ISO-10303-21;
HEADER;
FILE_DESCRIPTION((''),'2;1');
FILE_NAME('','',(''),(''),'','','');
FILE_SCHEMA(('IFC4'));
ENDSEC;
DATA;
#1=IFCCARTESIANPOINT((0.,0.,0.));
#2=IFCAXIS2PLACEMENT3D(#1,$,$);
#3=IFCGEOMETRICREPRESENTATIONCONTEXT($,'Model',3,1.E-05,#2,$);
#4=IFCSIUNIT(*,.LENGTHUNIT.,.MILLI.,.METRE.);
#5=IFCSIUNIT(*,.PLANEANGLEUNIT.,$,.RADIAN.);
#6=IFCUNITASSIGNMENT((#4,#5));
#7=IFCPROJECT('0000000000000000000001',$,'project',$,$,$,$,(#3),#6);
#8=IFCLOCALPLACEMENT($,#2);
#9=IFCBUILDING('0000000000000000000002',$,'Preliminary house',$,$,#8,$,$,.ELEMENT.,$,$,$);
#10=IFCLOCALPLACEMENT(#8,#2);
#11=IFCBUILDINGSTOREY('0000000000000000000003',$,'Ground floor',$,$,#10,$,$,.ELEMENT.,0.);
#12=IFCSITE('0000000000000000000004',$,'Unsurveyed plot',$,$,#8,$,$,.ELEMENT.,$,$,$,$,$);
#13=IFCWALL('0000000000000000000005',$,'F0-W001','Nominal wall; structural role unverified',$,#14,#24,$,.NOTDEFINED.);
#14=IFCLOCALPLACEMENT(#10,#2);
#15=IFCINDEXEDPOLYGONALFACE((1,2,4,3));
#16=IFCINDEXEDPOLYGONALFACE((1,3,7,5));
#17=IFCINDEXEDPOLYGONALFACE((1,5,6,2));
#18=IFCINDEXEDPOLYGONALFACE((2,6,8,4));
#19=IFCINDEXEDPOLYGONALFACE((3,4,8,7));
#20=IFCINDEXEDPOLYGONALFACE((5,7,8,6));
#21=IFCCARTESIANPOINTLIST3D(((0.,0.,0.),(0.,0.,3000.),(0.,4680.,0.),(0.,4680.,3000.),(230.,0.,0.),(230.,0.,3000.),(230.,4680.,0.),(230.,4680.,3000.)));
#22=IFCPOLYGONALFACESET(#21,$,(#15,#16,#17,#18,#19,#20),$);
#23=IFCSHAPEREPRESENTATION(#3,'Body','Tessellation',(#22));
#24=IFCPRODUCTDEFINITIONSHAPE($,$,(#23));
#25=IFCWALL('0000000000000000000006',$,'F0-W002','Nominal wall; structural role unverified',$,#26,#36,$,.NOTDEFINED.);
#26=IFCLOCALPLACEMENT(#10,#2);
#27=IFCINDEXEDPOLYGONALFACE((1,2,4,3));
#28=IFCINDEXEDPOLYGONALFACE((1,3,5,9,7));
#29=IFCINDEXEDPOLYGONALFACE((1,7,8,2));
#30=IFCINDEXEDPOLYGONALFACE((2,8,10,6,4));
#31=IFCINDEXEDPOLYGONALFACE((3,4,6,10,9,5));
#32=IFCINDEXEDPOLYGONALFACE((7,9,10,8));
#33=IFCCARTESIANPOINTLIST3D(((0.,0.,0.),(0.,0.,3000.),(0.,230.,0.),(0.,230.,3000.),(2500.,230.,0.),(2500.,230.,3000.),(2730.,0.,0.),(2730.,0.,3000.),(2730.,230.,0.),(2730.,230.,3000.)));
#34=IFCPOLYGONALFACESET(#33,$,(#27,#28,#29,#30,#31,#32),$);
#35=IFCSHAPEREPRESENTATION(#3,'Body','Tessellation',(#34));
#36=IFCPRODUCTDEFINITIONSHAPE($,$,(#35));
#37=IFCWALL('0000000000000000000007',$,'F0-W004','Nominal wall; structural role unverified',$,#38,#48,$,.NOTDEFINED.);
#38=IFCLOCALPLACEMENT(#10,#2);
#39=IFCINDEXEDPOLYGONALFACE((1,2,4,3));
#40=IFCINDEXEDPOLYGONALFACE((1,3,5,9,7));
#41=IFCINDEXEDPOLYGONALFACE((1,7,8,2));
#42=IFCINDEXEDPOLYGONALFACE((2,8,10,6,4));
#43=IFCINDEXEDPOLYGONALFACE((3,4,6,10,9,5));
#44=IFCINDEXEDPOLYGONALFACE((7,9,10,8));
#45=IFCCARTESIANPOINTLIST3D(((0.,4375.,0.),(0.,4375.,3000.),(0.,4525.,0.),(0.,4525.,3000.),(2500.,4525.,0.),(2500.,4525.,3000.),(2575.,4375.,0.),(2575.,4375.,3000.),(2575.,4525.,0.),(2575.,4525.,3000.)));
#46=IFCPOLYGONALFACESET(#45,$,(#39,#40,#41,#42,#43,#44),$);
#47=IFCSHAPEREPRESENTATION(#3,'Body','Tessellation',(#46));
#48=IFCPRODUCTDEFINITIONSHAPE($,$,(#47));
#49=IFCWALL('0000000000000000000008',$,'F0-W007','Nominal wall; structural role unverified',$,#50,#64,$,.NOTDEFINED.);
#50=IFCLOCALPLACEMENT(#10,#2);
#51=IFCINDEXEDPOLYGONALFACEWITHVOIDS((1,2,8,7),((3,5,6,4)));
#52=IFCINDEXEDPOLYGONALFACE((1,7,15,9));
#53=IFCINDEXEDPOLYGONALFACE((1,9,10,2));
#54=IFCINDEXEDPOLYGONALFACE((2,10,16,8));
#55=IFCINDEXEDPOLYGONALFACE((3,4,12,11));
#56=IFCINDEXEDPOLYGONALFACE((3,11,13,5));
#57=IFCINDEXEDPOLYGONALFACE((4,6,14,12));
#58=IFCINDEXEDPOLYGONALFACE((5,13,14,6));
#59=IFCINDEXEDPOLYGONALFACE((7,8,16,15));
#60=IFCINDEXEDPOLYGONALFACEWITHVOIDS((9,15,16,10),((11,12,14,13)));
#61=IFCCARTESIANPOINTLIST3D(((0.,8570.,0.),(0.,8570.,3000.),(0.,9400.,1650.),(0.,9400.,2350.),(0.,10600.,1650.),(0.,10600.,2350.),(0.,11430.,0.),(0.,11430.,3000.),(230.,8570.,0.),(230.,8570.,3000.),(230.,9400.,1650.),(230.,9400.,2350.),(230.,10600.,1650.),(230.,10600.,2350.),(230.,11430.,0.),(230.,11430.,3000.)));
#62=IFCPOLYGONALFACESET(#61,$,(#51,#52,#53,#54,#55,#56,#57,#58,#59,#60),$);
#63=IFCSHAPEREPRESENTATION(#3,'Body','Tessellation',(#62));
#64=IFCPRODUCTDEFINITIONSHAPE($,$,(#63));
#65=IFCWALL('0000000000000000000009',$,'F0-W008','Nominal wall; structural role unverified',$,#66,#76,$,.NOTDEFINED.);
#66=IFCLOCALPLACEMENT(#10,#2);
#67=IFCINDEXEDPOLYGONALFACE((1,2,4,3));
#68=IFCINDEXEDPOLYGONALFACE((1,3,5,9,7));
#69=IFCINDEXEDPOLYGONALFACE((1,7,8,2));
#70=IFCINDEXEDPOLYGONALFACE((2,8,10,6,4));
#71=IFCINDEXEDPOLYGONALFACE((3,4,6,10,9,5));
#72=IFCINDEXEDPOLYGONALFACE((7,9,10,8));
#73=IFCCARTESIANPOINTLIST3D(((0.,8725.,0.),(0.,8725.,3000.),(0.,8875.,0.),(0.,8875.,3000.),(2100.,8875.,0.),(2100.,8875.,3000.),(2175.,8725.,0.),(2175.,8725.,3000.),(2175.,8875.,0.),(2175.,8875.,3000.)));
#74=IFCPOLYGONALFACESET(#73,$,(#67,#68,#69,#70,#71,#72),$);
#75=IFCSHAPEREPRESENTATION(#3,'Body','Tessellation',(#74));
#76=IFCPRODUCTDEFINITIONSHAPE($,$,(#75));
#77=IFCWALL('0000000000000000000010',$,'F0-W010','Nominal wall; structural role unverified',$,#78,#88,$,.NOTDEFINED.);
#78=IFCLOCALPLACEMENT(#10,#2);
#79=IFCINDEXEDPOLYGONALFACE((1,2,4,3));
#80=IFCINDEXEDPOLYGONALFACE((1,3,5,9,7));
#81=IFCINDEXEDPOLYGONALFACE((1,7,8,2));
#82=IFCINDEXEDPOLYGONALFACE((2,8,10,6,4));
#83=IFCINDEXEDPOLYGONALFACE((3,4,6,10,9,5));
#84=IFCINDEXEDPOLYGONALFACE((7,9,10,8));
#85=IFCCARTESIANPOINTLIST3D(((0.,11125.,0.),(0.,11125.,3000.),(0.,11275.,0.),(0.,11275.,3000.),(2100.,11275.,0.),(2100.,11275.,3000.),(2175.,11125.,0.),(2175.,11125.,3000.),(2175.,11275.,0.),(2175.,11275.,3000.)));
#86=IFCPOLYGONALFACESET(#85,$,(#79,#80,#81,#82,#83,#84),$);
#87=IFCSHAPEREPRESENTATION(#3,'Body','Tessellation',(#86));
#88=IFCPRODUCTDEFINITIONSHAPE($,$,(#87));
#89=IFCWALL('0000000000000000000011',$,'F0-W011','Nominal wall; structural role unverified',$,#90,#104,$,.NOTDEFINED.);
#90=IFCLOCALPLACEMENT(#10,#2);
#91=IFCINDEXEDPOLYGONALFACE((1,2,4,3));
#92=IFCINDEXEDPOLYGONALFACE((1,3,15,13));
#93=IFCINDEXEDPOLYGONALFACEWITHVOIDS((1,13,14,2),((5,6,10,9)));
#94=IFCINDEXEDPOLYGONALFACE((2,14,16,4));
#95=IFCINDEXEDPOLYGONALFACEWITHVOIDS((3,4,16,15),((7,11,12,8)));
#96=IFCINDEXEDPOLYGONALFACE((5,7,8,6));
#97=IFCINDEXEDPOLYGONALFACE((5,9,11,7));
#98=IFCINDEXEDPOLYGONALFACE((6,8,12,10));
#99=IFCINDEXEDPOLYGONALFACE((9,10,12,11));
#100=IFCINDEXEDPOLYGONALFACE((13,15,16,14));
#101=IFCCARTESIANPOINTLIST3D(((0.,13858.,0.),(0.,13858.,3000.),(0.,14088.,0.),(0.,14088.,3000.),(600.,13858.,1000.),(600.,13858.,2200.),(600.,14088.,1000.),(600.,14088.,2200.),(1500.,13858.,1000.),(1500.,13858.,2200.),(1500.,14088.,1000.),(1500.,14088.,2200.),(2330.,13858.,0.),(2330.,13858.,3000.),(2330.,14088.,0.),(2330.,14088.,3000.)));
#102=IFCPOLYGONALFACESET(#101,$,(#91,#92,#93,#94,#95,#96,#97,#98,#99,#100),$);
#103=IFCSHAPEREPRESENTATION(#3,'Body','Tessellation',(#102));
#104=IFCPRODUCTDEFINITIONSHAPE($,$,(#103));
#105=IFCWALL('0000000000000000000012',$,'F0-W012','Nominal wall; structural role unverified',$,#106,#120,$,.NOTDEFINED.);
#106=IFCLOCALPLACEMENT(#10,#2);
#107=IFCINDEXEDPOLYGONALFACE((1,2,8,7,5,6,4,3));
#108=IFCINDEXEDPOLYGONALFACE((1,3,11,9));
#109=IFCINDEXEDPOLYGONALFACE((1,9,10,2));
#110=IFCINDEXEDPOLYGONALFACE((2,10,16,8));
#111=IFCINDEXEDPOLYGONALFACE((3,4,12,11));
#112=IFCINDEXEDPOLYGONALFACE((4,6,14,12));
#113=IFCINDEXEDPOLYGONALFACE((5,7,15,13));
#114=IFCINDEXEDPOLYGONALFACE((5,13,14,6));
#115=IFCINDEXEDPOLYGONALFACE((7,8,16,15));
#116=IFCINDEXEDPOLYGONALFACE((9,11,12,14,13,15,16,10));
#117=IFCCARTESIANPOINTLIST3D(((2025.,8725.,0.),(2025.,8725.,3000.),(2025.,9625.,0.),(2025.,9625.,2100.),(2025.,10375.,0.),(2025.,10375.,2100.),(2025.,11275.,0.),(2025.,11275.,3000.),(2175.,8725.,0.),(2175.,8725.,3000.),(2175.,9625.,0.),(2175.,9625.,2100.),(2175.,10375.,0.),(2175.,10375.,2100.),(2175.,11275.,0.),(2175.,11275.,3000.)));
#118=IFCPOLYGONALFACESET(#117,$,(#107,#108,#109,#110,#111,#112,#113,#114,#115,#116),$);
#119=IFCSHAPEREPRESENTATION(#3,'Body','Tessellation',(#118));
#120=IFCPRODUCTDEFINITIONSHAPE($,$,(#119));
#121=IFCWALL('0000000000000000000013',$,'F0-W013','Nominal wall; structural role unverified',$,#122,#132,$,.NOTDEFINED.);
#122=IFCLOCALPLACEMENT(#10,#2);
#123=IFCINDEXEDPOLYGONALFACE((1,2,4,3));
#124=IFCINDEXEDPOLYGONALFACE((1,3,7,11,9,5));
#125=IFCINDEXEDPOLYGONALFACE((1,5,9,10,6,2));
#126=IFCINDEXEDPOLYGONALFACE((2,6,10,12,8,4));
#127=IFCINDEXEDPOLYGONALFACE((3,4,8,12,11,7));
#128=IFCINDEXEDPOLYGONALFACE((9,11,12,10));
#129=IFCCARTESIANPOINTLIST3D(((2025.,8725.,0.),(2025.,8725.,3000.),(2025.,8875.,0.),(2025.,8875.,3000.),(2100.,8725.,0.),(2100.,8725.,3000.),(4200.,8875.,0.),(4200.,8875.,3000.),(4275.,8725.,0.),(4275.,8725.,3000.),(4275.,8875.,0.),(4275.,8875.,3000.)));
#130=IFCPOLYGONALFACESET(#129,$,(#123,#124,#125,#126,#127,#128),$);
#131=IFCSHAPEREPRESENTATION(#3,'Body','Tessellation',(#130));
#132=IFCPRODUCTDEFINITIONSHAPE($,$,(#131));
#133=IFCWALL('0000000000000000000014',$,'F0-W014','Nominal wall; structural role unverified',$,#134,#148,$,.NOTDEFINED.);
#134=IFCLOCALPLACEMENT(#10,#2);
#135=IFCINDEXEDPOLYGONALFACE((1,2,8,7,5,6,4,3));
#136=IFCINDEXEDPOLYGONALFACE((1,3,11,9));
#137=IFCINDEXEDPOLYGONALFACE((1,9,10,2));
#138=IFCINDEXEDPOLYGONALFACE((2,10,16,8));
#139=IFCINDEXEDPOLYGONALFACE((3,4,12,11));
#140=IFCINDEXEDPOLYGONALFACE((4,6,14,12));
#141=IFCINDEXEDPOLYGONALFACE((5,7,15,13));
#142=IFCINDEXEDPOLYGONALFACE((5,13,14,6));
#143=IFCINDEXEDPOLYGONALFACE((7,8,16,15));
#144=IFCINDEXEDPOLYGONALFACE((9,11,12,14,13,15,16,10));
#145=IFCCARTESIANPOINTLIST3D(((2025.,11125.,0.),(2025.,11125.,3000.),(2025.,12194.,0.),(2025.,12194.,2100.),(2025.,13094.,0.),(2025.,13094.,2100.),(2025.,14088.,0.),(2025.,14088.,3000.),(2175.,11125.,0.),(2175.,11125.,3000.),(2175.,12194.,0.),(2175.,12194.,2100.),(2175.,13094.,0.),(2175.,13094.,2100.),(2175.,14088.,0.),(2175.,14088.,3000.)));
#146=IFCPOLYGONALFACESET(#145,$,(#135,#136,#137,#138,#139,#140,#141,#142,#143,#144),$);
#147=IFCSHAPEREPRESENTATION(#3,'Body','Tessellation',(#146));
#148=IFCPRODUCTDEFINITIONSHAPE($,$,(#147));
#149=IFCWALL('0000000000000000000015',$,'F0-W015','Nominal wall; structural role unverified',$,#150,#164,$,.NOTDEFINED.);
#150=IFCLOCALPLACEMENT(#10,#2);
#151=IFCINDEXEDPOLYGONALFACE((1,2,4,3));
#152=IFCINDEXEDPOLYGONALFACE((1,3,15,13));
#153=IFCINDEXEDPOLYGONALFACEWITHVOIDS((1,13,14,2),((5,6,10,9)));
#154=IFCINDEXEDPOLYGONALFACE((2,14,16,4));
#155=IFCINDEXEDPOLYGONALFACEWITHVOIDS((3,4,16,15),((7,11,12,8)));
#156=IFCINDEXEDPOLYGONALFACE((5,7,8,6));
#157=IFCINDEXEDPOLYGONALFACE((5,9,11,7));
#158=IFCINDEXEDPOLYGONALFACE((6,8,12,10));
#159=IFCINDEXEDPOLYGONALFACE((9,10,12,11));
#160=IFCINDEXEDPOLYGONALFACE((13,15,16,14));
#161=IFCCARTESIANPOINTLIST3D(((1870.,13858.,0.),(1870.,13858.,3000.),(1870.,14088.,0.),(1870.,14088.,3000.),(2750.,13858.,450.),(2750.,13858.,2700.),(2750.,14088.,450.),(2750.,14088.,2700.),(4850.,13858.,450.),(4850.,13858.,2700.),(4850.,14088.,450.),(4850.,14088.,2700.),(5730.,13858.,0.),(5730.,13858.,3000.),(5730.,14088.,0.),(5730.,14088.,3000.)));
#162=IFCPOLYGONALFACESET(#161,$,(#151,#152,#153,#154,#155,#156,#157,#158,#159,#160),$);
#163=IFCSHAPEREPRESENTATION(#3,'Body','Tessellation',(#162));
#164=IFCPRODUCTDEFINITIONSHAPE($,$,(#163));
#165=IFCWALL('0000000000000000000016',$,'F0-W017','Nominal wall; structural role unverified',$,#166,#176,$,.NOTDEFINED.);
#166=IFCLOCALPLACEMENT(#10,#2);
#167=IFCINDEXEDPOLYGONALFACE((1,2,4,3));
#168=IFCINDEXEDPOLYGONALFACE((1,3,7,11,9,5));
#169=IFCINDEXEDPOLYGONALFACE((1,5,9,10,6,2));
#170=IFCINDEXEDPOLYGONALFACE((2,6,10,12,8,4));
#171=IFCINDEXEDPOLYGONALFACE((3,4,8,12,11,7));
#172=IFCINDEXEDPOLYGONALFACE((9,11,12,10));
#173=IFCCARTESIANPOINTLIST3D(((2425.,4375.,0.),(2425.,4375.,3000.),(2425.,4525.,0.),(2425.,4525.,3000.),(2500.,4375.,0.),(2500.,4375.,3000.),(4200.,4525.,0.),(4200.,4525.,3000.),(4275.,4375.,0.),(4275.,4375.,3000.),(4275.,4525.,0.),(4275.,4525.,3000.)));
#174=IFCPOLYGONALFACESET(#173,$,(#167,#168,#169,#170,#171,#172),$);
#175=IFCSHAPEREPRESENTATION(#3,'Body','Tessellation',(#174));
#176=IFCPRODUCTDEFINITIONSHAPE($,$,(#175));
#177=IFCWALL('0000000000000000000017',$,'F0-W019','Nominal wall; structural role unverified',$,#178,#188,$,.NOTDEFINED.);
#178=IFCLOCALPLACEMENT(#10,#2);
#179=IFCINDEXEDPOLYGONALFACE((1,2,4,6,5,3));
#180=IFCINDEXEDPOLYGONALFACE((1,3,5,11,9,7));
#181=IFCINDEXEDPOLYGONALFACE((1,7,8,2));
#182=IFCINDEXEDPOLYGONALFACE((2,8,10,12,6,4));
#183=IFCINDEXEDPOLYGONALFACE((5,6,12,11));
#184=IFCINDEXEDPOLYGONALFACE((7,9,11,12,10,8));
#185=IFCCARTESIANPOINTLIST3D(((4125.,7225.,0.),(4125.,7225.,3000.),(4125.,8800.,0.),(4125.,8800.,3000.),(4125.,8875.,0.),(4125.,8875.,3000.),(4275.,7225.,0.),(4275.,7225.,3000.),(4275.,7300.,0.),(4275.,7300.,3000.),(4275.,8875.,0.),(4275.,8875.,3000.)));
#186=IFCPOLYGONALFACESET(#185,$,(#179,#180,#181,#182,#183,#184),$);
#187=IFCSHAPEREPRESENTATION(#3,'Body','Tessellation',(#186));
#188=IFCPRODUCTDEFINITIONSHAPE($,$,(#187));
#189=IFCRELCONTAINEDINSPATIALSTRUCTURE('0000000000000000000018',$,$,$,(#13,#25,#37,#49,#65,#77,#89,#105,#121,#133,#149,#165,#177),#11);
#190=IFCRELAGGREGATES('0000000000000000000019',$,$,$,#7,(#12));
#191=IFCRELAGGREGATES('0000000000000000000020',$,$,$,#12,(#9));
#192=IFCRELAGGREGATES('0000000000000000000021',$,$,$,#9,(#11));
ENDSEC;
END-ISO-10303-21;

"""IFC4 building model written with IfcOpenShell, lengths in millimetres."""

from ifc_helpers import new_model, si_unit, frame, origin, place, context, project, spatial, polyline, outline, extrude, element, save


model = new_model("IFC4")

# Units and contexts
model_context = context("Model", 3, precision=1e-05, world=origin())
ifc_project = project(units=[si_unit("LENGTHUNIT", "METRE", prefix="MILLI"), si_unit("PLANEANGLEUNIT", "RADIAN")], contexts=[model_context])

# Site, building, storey
placement_1 = place(None, origin())
site = spatial("IfcSite", under=ifc_project, at=placement_1, Name="Unsurveyed plot", CompositionType="ELEMENT")
building = spatial("IfcBuilding", under=site, at=placement_1, Name="Preliminary house", CompositionType="ELEMENT")
placement_2 = place(placement_1, origin())
storey = spatial("IfcBuildingStorey", under=building, at=placement_2, Name="Ground floor", CompositionType="ELEMENT", Elevation=0.0)

# Walls
element("IfcWall", 1, at=placement_2, inside=storey, Name="F0-W001", Description="Nominal wall; structural role unverified", PredefinedType="NOTDEFINED", context=model_context, shape_type="SweptSolid", body=[
    extrude(outline(polyline([(230.0, 4680.0), (230.0, 0.0), (0.0, 0.0), (0.0, 4680.0), (230.0, 4680.0)])), origin(), (0.0, 0.0, 1.0), 3000.0),
])
element("IfcWall", 2, at=placement_2, inside=storey, Name="F0-W002", Description="Nominal wall; structural role unverified", PredefinedType="NOTDEFINED", context=model_context, shape_type="SweptSolid", body=[
    extrude(outline(polyline([(2730.0, 230.0), (2730.0, 0.0), (0.0, 0.0), (0.0, 230.0), (2500.0, 230.0), (2730.0, 230.0)])), origin(), (0.0, 0.0, 1.0), 3000.0),
])

# Wall
element("IfcWall", 3, at=placement_2, inside=storey, Name="F0-W004", Description="Nominal wall; structural role unverified", PredefinedType="NOTDEFINED", context=model_context, shape_type="SweptSolid", body=[
    extrude(outline(polyline([(2575.0, 4525.0), (2575.0, 4375.0), (0.0, 4375.0), (0.0, 4525.0), (2500.0, 4525.0), (2575.0, 4525.0)])), origin(), (0.0, 0.0, 1.0), 3000.0),
])

# Wall, opening
wall_1 = element("IfcWall", 4, at=placement_2, inside=storey, Name="F0-W007", Description="Nominal wall; structural role unverified", PredefinedType="NOTDEFINED", context=model_context, shape_type="SweptSolid", body=[
    extrude(outline(polyline([(230.0, 11430.0), (230.0, 8800.0), (230.0, 8570.0), (0.0, 8570.0), (0.0, 11430.0), (230.0, 11430.0)])), origin(), (0.0, 0.0, 1.0), 3000.0),
])
element("IfcOpeningElement", 5, at=placement_2, cuts=wall_1, PredefinedType="OPENING", context=model_context, shape_type="SweptSolid", body=[
    extrude(outline(polyline([(645.0, 9400.0), (645.0, 10600.0), (-415.0, 10600.0), (-415.0, 9400.0), (645.0, 9400.0)])), frame((0.0, 0.0, 1650.0)), (0.0, 0.0, 1.0), 700.0),
])

# Wall
element("IfcWall", 6, at=placement_2, inside=storey, Name="F0-W008", Description="Nominal wall; structural role unverified", PredefinedType="NOTDEFINED", context=model_context, shape_type="SweptSolid", body=[
    extrude(outline(polyline([(2175.0, 8875.0), (2175.0, 8725.0), (0.0, 8725.0), (0.0, 8875.0), (2100.0, 8875.0), (2175.0, 8875.0)])), origin(), (0.0, 0.0, 1.0), 3000.0),
])

# Wall
element("IfcWall", 7, at=placement_2, inside=storey, Name="F0-W010", Description="Nominal wall; structural role unverified", PredefinedType="NOTDEFINED", context=model_context, shape_type="SweptSolid", body=[
    extrude(outline(polyline([(2175.0, 11275.0), (2175.0, 11125.0), (0.0, 11125.0), (0.0, 11275.0), (2100.0, 11275.0), (2175.0, 11275.0)])), origin(), (0.0, 0.0, 1.0), 3000.0),
])

# Walls, openings
wall_2 = element("IfcWall", 8, at=placement_2, inside=storey, Name="F0-W011", Description="Nominal wall; structural role unverified", PredefinedType="NOTDEFINED", context=model_context, shape_type="SweptSolid", body=[
    extrude(outline(polyline([(2330.0, 13858.0), (0.0, 13858.0), (0.0, 14088.0), (2330.0, 14088.0), (2330.0, 13858.0)])), origin(), (0.0, 0.0, 1.0), 3000.0),
])
element("IfcOpeningElement", 9, at=placement_2, cuts=wall_2, PredefinedType="OPENING", context=model_context, shape_type="SweptSolid", body=[
    extrude(outline(polyline([(600.0, 13443.0), (1500.0, 13443.0), (1500.0, 14503.0), (600.0, 14503.0), (600.0, 13443.0)])), frame((0.0, 0.0, 1000.0)), (0.0, 0.0, 1.0), 1200.0),
])
wall_3 = element("IfcWall", 10, at=placement_2, inside=storey, Name="F0-W012", Description="Nominal wall; structural role unverified", PredefinedType="NOTDEFINED", context=model_context, shape_type="SweptSolid", body=[
    extrude(outline(polyline([(2025.0, 11275.0), (2175.0, 11275.0), (2175.0, 8800.0), (2175.0, 8725.0), (2025.0, 8725.0), (2025.0, 11200.0), (2025.0, 11275.0)])), origin(), (0.0, 0.0, 1.0), 3000.0),
])
element("IfcOpeningElement", 11, at=placement_2, cuts=wall_3, PredefinedType="OPENING", context=model_context, shape_type="SweptSolid", body=[
    extrude(outline(polyline([(2550.0, 9625.0), (2550.0, 10375.0), (1650.0, 10375.0), (1650.0, 9625.0), (2550.0, 9625.0)])), origin(), (0.0, 0.0, 1.0), 2100.0),
])

# Wall
element("IfcWall", 12, at=placement_2, inside=storey, Name="F0-W013", Description="Nominal wall; structural role unverified", PredefinedType="NOTDEFINED", context=model_context, shape_type="SweptSolid", body=[
    extrude(outline(polyline([(4275.0, 8875.0), (4275.0, 8725.0), (2100.0, 8725.0), (2025.0, 8725.0), (2025.0, 8875.0), (4200.0, 8875.0), (4275.0, 8875.0)])), origin(), (0.0, 0.0, 1.0), 3000.0),
])

# Walls, openings
wall_4 = element("IfcWall", 13, at=placement_2, inside=storey, Name="F0-W014", Description="Nominal wall; structural role unverified", PredefinedType="NOTDEFINED", context=model_context, shape_type="SweptSolid", body=[
    extrude(outline(polyline([(2175.0, 11200.0), (2175.0, 11125.0), (2025.0, 11125.0), (2025.0, 14088.0), (2175.0, 14088.0), (2175.0, 11200.0)])), origin(), (0.0, 0.0, 1.0), 3000.0),
])
element("IfcOpeningElement", 14, at=placement_2, cuts=wall_4, PredefinedType="OPENING", context=model_context, shape_type="SweptSolid", body=[
    extrude(outline(polyline([(2550.0, 12194.0), (2550.0, 13094.0), (1650.0, 13094.0), (1650.0, 12194.0), (2550.0, 12194.0)])), origin(), (0.0, 0.0, 1.0), 2100.0),
])
wall_5 = element("IfcWall", 15, at=placement_2, inside=storey, Name="F0-W015", Description="Nominal wall; structural role unverified", PredefinedType="NOTDEFINED", context=model_context, shape_type="SweptSolid", body=[
    extrude(outline(polyline([(5730.0, 13858.0), (2100.0, 13858.0), (1870.0, 13858.0), (1870.0, 14088.0), (5730.0, 14088.0), (5730.0, 13858.0)])), origin(), (0.0, 0.0, 1.0), 3000.0),
])
element("IfcOpeningElement", 16, at=placement_2, cuts=wall_5, PredefinedType="OPENING", context=model_context, shape_type="SweptSolid", body=[
    extrude(outline(polyline([(2750.0, 13443.0), (4850.0, 13443.0), (4850.0, 14503.0), (2750.0, 14503.0), (2750.0, 13443.0)])), frame((0.0, 0.0, 450.0)), (0.0, 0.0, 1.0), 2250.0),
])

# Wall
element("IfcWall", 17, at=placement_2, inside=storey, Name="F0-W017", Description="Nominal wall; structural role unverified", PredefinedType="NOTDEFINED", context=model_context, shape_type="SweptSolid", body=[
    extrude(outline(polyline([(4275.0, 4525.0), (4275.0, 4375.0), (2500.0, 4375.0), (2425.0, 4375.0), (2425.0, 4525.0), (4200.0, 4525.0), (4275.0, 4525.0)])), origin(), (0.0, 0.0, 1.0), 3000.0),
])

# Wall
element("IfcWall", 18, at=placement_2, inside=storey, Name="F0-W019", Description="Nominal wall; structural role unverified", PredefinedType="NOTDEFINED", context=model_context, shape_type="SweptSolid", body=[
    extrude(outline(polyline([(4125.0, 8875.0), (4275.0, 8875.0), (4275.0, 7300.0), (4275.0, 7225.0), (4125.0, 7225.0), (4125.0, 8800.0), (4125.0, 8875.0)])), origin(), (0.0, 0.0, 1.0), 3000.0),
])

save(model, "model.ifc")
